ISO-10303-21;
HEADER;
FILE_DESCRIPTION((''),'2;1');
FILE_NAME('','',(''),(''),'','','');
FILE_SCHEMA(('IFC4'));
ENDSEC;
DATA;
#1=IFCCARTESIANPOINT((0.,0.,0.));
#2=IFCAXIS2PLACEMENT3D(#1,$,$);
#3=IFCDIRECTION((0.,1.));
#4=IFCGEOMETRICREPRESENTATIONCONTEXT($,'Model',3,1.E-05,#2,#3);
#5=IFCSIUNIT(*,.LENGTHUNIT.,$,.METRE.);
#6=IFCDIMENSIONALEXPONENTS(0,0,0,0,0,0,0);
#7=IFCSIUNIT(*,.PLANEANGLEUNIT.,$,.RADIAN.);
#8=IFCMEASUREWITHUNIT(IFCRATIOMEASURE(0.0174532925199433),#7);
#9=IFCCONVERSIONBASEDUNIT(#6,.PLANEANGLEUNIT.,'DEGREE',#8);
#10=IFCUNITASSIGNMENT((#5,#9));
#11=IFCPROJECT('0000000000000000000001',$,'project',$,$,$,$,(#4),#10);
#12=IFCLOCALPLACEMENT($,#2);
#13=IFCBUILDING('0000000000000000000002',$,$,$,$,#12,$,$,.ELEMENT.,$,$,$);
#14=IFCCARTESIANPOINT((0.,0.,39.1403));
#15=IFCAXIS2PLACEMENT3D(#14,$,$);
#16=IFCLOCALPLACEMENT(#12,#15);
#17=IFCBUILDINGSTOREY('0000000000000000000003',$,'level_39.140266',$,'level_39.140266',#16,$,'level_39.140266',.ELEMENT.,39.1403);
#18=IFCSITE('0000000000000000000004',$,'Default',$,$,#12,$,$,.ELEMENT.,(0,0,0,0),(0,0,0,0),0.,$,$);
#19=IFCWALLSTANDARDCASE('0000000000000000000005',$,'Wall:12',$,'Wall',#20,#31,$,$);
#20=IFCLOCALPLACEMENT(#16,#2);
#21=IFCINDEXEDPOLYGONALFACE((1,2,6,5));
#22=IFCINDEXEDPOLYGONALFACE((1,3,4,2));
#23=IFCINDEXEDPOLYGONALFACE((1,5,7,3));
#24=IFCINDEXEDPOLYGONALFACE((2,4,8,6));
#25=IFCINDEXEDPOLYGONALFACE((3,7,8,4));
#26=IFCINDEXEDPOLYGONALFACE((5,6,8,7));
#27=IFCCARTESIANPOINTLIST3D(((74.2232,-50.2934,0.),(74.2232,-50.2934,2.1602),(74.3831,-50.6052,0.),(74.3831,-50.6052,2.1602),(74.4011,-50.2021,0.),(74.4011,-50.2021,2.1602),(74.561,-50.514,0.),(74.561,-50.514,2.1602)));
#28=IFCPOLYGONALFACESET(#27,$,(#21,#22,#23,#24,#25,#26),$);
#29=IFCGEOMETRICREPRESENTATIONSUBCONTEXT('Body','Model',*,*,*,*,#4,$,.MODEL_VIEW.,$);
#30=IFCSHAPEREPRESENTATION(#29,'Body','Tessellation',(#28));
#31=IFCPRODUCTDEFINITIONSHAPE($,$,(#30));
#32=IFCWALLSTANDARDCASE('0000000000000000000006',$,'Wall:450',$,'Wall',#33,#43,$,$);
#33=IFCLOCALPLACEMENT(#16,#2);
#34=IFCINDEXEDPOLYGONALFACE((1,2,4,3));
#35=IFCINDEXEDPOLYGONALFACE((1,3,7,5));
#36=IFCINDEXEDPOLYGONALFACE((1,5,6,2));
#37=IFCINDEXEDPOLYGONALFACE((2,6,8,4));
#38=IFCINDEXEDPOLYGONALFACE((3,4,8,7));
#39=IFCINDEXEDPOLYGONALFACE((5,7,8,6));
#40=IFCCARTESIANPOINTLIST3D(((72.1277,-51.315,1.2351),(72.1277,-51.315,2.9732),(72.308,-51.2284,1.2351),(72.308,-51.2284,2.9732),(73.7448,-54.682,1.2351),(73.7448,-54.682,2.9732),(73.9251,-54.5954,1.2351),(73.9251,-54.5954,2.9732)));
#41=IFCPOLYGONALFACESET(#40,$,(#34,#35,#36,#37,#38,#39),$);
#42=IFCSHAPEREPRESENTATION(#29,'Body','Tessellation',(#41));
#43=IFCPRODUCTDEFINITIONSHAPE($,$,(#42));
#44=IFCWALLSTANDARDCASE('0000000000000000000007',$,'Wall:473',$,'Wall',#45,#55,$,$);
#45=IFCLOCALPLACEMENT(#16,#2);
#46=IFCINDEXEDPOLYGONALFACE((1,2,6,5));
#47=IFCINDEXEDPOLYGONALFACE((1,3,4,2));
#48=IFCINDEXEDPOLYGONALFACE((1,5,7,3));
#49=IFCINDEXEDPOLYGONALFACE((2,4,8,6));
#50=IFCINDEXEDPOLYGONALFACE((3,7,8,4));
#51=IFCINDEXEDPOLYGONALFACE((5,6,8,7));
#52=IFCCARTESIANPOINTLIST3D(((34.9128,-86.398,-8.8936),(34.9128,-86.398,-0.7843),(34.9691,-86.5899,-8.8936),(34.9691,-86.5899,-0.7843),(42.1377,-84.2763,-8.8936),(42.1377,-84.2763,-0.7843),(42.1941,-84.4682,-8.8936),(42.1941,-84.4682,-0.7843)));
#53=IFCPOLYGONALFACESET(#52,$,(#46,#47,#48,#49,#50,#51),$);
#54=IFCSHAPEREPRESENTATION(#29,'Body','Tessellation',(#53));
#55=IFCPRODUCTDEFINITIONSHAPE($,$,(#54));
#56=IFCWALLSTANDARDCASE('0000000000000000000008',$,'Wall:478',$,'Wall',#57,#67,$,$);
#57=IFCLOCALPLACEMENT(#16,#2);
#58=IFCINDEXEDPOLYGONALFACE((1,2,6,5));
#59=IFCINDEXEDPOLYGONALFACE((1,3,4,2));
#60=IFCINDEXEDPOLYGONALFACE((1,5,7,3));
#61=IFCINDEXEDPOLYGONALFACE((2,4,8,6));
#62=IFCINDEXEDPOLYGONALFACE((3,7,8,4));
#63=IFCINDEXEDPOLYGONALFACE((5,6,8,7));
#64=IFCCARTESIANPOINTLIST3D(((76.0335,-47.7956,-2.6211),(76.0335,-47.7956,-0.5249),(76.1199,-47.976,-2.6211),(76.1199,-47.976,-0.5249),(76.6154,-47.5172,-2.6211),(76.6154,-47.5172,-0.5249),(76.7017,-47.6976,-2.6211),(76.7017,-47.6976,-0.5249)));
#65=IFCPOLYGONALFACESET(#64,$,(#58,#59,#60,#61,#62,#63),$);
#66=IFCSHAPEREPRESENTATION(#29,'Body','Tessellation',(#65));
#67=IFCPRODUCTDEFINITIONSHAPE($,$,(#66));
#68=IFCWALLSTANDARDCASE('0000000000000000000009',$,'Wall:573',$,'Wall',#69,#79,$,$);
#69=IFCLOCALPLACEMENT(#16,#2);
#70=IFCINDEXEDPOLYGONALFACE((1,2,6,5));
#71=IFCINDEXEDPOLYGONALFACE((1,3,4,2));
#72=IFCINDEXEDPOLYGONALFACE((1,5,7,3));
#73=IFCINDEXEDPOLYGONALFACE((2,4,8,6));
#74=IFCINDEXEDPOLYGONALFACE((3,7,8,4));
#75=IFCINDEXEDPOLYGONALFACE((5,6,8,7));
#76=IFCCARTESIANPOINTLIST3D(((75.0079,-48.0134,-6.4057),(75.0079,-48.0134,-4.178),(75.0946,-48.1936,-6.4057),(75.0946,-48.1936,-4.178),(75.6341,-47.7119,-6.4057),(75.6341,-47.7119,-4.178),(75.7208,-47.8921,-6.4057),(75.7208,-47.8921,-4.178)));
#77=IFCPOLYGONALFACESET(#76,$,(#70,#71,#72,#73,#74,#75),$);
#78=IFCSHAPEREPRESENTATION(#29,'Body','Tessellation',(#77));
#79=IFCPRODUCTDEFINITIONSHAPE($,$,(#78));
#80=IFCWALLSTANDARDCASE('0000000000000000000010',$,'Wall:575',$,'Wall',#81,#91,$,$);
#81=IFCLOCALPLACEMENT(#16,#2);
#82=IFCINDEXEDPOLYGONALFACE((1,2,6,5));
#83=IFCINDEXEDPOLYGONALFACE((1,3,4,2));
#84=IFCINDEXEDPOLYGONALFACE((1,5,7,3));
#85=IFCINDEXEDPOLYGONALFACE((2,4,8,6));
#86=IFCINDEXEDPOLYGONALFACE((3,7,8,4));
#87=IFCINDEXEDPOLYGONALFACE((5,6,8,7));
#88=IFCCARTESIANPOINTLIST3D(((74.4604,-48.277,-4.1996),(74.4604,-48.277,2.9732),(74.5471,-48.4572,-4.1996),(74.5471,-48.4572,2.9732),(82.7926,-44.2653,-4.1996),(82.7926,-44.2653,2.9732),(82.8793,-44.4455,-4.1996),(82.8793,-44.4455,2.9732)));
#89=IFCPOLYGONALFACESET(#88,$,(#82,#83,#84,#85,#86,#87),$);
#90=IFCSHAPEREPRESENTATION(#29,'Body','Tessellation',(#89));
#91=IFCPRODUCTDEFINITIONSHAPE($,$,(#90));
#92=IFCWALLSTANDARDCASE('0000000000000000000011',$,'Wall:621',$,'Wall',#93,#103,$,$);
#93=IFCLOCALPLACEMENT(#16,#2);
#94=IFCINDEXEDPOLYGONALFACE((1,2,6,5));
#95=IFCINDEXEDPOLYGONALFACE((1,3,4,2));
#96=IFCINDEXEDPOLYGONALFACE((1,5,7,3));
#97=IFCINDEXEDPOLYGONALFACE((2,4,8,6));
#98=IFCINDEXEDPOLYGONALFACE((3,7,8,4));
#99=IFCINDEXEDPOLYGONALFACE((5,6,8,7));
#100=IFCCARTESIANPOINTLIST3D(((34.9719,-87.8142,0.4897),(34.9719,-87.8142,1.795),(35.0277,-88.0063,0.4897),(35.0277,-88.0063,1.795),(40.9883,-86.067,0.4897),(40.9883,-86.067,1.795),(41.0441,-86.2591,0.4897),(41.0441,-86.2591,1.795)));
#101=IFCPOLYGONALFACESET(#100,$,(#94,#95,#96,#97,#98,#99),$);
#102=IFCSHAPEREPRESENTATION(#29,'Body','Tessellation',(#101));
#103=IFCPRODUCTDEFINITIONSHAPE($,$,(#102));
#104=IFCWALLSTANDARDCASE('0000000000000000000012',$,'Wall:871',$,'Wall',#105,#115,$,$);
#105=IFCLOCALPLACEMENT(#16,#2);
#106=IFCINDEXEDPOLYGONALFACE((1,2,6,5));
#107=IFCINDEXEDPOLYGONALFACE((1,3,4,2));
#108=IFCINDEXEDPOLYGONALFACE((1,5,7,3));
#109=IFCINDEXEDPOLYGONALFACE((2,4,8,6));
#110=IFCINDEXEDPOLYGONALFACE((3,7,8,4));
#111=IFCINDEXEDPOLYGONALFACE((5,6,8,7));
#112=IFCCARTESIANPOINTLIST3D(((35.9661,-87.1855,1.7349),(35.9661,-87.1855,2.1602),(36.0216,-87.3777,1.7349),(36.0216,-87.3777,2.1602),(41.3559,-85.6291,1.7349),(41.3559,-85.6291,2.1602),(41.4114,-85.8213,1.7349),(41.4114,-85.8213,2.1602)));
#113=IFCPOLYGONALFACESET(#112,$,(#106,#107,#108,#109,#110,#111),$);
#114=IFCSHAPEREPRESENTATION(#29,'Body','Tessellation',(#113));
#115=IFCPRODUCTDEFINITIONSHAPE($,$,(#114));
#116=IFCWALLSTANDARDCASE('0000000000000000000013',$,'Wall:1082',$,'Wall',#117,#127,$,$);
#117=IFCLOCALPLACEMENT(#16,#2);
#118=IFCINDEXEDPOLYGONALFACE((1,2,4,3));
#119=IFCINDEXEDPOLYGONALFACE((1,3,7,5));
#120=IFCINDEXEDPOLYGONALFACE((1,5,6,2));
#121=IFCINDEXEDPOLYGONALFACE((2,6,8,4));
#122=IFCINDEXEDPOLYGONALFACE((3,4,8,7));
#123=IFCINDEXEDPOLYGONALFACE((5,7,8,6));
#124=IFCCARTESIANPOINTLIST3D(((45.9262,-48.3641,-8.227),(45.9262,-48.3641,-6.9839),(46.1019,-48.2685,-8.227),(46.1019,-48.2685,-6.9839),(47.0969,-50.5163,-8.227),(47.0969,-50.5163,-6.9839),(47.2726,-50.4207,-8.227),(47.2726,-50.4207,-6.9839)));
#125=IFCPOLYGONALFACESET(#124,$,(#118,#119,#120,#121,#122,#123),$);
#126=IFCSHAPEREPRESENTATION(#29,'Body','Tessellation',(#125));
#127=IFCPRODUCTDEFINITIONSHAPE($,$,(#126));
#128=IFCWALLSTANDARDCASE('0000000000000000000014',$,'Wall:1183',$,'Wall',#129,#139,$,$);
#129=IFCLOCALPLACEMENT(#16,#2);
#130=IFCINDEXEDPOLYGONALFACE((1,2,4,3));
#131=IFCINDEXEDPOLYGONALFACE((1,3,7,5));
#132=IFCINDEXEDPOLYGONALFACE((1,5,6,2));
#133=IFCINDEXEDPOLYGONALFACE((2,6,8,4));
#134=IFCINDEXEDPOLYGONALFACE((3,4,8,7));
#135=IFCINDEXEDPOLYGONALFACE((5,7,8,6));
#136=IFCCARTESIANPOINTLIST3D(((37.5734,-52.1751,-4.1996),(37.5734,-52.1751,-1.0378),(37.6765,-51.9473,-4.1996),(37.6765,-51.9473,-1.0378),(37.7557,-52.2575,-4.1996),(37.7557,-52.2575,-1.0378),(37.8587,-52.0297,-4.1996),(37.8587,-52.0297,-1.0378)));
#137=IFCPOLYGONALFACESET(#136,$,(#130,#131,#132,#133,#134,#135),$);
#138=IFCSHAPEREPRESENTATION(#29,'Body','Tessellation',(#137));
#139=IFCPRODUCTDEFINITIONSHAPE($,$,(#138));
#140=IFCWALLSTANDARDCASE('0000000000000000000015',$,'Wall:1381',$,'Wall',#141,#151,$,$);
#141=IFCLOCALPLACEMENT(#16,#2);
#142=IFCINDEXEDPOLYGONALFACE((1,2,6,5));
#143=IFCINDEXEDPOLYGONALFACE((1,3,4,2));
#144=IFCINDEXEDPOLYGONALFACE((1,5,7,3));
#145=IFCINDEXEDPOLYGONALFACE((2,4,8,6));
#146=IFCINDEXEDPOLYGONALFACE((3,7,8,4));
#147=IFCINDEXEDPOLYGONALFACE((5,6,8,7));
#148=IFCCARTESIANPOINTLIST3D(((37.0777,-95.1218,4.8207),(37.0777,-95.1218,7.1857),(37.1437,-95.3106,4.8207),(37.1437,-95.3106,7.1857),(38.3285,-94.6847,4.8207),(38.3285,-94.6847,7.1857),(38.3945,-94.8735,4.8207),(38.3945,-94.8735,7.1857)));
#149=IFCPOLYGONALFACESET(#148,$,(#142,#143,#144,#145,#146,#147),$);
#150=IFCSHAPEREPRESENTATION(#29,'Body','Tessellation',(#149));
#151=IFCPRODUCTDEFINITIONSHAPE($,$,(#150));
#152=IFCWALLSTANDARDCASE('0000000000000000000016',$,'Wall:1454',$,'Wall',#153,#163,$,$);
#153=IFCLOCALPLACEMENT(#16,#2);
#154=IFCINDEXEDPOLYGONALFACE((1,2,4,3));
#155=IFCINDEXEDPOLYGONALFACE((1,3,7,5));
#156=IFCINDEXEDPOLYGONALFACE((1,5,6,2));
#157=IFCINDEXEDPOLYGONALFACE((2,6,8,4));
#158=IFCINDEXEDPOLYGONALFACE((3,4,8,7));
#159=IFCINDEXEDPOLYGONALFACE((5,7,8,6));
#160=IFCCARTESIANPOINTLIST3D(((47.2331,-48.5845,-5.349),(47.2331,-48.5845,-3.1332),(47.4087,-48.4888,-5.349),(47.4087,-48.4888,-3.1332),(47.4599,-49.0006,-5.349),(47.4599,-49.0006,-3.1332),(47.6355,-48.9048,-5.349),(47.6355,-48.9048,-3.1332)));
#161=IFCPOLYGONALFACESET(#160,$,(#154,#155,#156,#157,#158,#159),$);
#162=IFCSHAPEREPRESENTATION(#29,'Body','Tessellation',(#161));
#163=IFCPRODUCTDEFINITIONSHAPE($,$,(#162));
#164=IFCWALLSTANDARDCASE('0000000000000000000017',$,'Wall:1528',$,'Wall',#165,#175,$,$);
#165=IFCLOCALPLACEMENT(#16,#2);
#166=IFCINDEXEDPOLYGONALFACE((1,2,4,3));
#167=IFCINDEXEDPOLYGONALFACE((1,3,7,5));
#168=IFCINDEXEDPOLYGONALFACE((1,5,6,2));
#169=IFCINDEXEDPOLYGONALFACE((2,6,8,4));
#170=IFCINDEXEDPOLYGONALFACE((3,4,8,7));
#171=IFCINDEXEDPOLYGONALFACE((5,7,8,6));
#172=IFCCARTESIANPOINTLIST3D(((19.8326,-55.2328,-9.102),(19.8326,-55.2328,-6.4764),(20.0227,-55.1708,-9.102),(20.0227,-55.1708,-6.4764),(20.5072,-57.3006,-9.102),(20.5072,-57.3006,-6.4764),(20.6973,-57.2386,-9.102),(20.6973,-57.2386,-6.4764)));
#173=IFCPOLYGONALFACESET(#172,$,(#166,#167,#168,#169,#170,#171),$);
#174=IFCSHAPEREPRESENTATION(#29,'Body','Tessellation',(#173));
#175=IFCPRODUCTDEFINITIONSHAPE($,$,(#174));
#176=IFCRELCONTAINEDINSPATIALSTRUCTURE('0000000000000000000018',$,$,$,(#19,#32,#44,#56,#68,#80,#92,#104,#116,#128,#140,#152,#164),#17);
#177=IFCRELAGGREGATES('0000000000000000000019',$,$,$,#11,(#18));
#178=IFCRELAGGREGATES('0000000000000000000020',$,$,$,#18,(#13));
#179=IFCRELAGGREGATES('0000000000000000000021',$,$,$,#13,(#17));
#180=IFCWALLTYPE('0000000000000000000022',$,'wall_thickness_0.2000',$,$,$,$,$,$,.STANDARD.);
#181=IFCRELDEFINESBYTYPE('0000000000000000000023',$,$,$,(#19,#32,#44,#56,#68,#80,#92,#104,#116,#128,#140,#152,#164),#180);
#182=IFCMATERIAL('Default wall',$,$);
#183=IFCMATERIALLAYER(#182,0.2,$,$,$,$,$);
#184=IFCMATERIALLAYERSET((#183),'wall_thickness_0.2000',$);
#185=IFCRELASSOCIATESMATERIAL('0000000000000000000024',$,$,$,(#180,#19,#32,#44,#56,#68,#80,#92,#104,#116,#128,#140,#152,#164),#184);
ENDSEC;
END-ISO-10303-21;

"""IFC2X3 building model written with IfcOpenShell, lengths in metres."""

from ifc_helpers import new_model, entity, si_unit, converted_unit, direction, frame, origin, place, context, subcontext, project, spatial, polyline, outline, extrude, material, layer, layer_set, layer_usage, type_object, element, save


model = new_model("IFC2X3")

# Units and contexts
model_context = context("Model", 3, precision=1e-05, world=origin(), true_north=direction((0.0, 1.0)))
body_context = subcontext(model_context, "Body", "Model", "MODEL_VIEW")
ifc_project = project(units=[si_unit("LENGTHUNIT", "METRE"), converted_unit("PLANEANGLEUNIT", "DEGREE", entity("IfcRatioMeasure", 0.0174532925199433), si_unit("PLANEANGLEUNIT", "RADIAN"), dimensions=[0, 0, 0, 0, 0, 0, 0])], contexts=[model_context])

# Site, building, storey
placement_1 = place(None, origin())
site = spatial("IfcSite", under=ifc_project, at=placement_1, Name="Default", CompositionType="ELEMENT", RefLatitude=(0, 0, 0, 0), RefLongitude=(0, 0, 0, 0), RefElevation=0.0)
building = spatial("IfcBuilding", under=site, at=placement_1, CompositionType="ELEMENT")
storey_placement = place(placement_1, frame((0.0, 0.0, 39.1403)))
storey = spatial("IfcBuildingStorey", under=building, at=storey_placement, Name="level_39.140266", ObjectType="level_39.140266", LongName="level_39.140266", CompositionType="ELEMENT", Elevation=39.1403)

# Walls
ifc_material_1 = material(Name="Default wall")
ifc_layer = layer(ifc_material_1, 0.2)
ifc_layer_set = layer_set([ifc_layer], Name="wall_thickness_0.2000")
ifc_layer_usage = layer_usage(ifc_layer_set, "AXIS2", "POSITIVE", -0.1)
wall_type = type_object("IfcWallType", Name="wall_thickness_0.2000", PredefinedType="STANDARD", material=ifc_layer_set)
wall_1_placement = place(storey_placement, frame((74.472, -50.5596, 0.0), z_axis=(0.0, 0.0, 1.0), x_axis=(-0.456269, 0.889842, 0.0)))
element("IfcWallStandardCase", 1, at=wall_1_placement, inside=storey, type_object=wall_type, material=ifc_layer_usage, Name="Wall:12", ObjectType="Wall", context=body_context, shape_type="SweptSolid", body=[
    extrude(outline(polyline([(0.3504, -0.1), (0.3504, 0.1), (0.0, 0.1), (0.0, -0.1), (0.3504, -0.1)])), origin(), (0.0, 0.0, 1.0), 2.1602),
])
placement_2 = place(placement_1, frame((0.0, 0.0, 40.3754)))
wall_2_placement = place(placement_2, frame((72.2179, -51.2717, 0.0), z_axis=(0.0, 0.0, 1.0), x_axis=(0.432938, -0.901424, 0.0)))
element("IfcWallStandardCase", 2, at=wall_2_placement, inside=storey, type_object=wall_type, material=ifc_layer_usage, Name="Wall:450", ObjectType="Wall", context=body_context, shape_type="SweptSolid", body=[
    extrude(outline(polyline([(3.7352, -0.1), (3.7352, 0.1), (0.0, 0.1), (0.0, -0.1), (3.7352, -0.1)])), origin(), (0.0, 0.0, 1.0), 1.7382),
])
placement_3 = place(placement_1, frame((0.0, 0.0, 30.2467)))
wall_3_placement = place(placement_3, frame((34.941, -86.4939, 0.0), z_axis=(0.0, 0.0, 1.0), x_axis=(0.959485, 0.281761, 0.0)))
element("IfcWallStandardCase", 3, at=wall_3_placement, inside=storey, type_object=wall_type, material=ifc_layer_usage, Name="Wall:473", ObjectType="Wall", context=body_context, shape_type="SweptSolid", body=[
    extrude(outline(polyline([(7.53, -0.1), (7.53, 0.1), (0.0, 0.1), (0.0, -0.1), (7.53, -0.1)])), origin(), (0.0, 0.0, 1.0), 8.1093),
])
placement_4 = place(placement_1, frame((0.0, 0.0, 36.5192)))
wall_4_placement = place(placement_4, frame((76.0767, -47.8858, 0.0), z_axis=(0.0, 0.0, 1.0), x_axis=(0.90205, 0.431632, 0.0)))
element("IfcWallStandardCase", 4, at=wall_4_placement, inside=storey, type_object=wall_type, material=ifc_layer_usage, Name="Wall:478", ObjectType="Wall", context=body_context, shape_type="SweptSolid", body=[
    extrude(outline(polyline([(0.645, -0.1), (0.645, 0.1), (0.0, 0.1), (0.0, -0.1), (0.645, -0.1)])), origin(), (0.0, 0.0, 1.0), 2.0962),
])
placement_5 = place(placement_1, frame((0.0, 0.0, 32.7346)))
wall_5_placement = place(placement_5, frame((75.0512, -48.1035, 0.0), z_axis=(0.0, 0.0, 1.0), x_axis=(0.901006, 0.433806, 0.0)))
element("IfcWallStandardCase", 5, at=wall_5_placement, inside=storey, type_object=wall_type, material=ifc_layer_usage, Name="Wall:573", ObjectType="Wall", context=body_context, shape_type="SweptSolid", body=[
    extrude(outline(polyline([(0.695, -0.1), (0.695, 0.1), (0.0, 0.1), (0.0, -0.1), (0.695, -0.1)])), origin(), (0.0, 0.0, 1.0), 2.2277),
])
placement_6 = place(placement_1, frame((0.0, 0.0, 34.9407)))
wall_6_placement = place(placement_6, frame((74.5038, -48.3671, 0.0), z_axis=(0.0, 0.0, 1.0), x_axis=(0.901007, 0.433805, 0.0)))
element("IfcWallStandardCase", 6, at=wall_6_placement, inside=storey, type_object=wall_type, material=ifc_layer_usage, Name="Wall:575", ObjectType="Wall", context=body_context, shape_type="SweptSolid", body=[
    extrude(outline(polyline([(9.2476, -0.1), (9.2476, 0.1), (0.0, 0.1), (0.0, -0.1), (9.2476, -0.1)])), origin(), (0.0, 0.0, 1.0), 7.1729),
])
placement_7 = place(placement_1, frame((0.0, 0.0, 39.63)))
wall_7_placement = place(placement_7, frame((34.9998, -87.9103, 0.0), z_axis=(0.0, 0.0, 1.0), x_axis=(0.960323, 0.27889, 0.0)))
element("IfcWallStandardCase", 7, at=wall_7_placement, inside=storey, type_object=wall_type, material=ifc_layer_usage, Name="Wall:621", ObjectType="Wall", context=body_context, shape_type="SweptSolid", body=[
    extrude(outline(polyline([(6.265, -0.1), (6.265, 0.1), (0.0, 0.1), (0.0, -0.1), (6.265, -0.1)])), origin(), (0.0, 0.0, 1.0), 1.3053),
])
placement_8 = place(placement_1, frame((0.0, 0.0, 40.8752)))
wall_8_placement = place(placement_8, frame((35.9939, -87.2816, 0.0), z_axis=(0.0, 0.0, 1.0), x_axis=(0.960745, 0.277431, 0.0)))
element("IfcWallStandardCase", 8, at=wall_8_placement, inside=storey, type_object=wall_type, material=ifc_layer_usage, Name="Wall:871", ObjectType="Wall", context=body_context, shape_type="SweptSolid", body=[
    extrude(outline(polyline([(5.61, -0.1), (5.61, 0.1), (0.0, 0.1), (0.0, -0.1), (5.61, -0.1)])), origin(), (0.0, 0.0, 1.0), 0.4253),
])
placement_9 = place(placement_1, frame((0.0, 0.0, 30.9133)))
wall_9_placement = place(placement_9, frame((46.0141, -48.3163, 0.0), z_axis=(0.0, 0.0, 1.0), x_axis=(0.477828, -0.878454, 0.0)))
element("IfcWallStandardCase", 9, at=wall_9_placement, inside=storey, type_object=wall_type, material=ifc_layer_usage, Name="Wall:1082", ObjectType="Wall", context=body_context, shape_type="SweptSolid", body=[
    extrude(outline(polyline([(2.45, -0.1), (2.45, 0.1), (0.0, 0.1), (0.0, -0.1), (2.45, -0.1)])), origin(), (0.0, 0.0, 1.0), 1.2431),
])
placement_10 = place(placement_1, frame((0.0, 0.0, 34.9407)))
wall_10_placement = place(placement_10, frame((37.7676, -51.9885, 0.0), z_axis=(0.0, 0.0, 1.0), x_axis=(-0.412029, -0.911171, 0.0)))
element("IfcWallStandardCase", 10, at=wall_10_placement, inside=storey, type_object=wall_type, material=ifc_layer_usage, Name="Wall:1183", ObjectType="Wall", context=body_context, shape_type="SweptSolid", body=[
    extrude(outline(polyline([(0.25, -0.1), (0.25, 0.1), (0.0, 0.1), (0.0, -0.1), (0.25, -0.1)])), origin(), (0.0, 0.0, 1.0), 3.1619),
])
placement_11 = place(placement_1, frame((0.0, 0.0, 43.961)))
wall_11_placement = place(placement_11, frame((37.1107, -95.2162, 0.0), z_axis=(0.0, 0.0, 1.0), x_axis=(0.944006, 0.329929, 0.0)))
element("IfcWallStandardCase", 11, at=wall_11_placement, inside=storey, type_object=wall_type, material=ifc_layer_usage, Name="Wall:1381", ObjectType="Wall", context=body_context, shape_type="SweptSolid", body=[
    extrude(outline(polyline([(1.325, -0.1), (1.325, 0.1), (0.0, 0.1), (0.0, -0.1), (1.325, -0.1)])), origin(), (0.0, 0.0, 1.0), 2.365),
])
placement_12 = place(placement_1, frame((0.0, 0.0, 33.7913)))
wall_12_placement = place(placement_12, frame((47.5477, -48.9527, 0.0), z_axis=(0.0, 0.0, 1.0), x_axis=(-0.478686, 0.877986, 0.0)))
element("IfcWallStandardCase", 12, at=wall_12_placement, inside=storey, type_object=wall_type, material=ifc_layer_usage, Name="Wall:1454", ObjectType="Wall", context=body_context, shape_type="SweptSolid", body=[
    extrude(outline(polyline([(0.4739, -0.1), (0.4739, 0.1), (0.0, 0.1), (0.0, -0.1), (0.4739, -0.1)])), origin(), (0.0, 0.0, 1.0), 2.2157),
])
placement_13 = place(placement_1, frame((0.0, 0.0, 30.0383)))
wall_13_placement = place(placement_13, frame((20.6022, -57.2696, 0.0), z_axis=(0.0, 0.0, 1.0), x_axis=(-0.310151, 0.950687, 0.0)))
element("IfcWallStandardCase", 13, at=wall_13_placement, inside=storey, type_object=wall_type, material=ifc_layer_usage, Name="Wall:1528", ObjectType="Wall", context=body_context, shape_type="SweptSolid", body=[
    extrude(outline(polyline([(2.175, -0.1), (2.175, 0.1), (0.0, 0.1), (0.0, -0.1), (2.175, -0.1)])), origin(), (0.0, 0.0, 1.0), 2.6256),
])

save(model, "model.ifc")
